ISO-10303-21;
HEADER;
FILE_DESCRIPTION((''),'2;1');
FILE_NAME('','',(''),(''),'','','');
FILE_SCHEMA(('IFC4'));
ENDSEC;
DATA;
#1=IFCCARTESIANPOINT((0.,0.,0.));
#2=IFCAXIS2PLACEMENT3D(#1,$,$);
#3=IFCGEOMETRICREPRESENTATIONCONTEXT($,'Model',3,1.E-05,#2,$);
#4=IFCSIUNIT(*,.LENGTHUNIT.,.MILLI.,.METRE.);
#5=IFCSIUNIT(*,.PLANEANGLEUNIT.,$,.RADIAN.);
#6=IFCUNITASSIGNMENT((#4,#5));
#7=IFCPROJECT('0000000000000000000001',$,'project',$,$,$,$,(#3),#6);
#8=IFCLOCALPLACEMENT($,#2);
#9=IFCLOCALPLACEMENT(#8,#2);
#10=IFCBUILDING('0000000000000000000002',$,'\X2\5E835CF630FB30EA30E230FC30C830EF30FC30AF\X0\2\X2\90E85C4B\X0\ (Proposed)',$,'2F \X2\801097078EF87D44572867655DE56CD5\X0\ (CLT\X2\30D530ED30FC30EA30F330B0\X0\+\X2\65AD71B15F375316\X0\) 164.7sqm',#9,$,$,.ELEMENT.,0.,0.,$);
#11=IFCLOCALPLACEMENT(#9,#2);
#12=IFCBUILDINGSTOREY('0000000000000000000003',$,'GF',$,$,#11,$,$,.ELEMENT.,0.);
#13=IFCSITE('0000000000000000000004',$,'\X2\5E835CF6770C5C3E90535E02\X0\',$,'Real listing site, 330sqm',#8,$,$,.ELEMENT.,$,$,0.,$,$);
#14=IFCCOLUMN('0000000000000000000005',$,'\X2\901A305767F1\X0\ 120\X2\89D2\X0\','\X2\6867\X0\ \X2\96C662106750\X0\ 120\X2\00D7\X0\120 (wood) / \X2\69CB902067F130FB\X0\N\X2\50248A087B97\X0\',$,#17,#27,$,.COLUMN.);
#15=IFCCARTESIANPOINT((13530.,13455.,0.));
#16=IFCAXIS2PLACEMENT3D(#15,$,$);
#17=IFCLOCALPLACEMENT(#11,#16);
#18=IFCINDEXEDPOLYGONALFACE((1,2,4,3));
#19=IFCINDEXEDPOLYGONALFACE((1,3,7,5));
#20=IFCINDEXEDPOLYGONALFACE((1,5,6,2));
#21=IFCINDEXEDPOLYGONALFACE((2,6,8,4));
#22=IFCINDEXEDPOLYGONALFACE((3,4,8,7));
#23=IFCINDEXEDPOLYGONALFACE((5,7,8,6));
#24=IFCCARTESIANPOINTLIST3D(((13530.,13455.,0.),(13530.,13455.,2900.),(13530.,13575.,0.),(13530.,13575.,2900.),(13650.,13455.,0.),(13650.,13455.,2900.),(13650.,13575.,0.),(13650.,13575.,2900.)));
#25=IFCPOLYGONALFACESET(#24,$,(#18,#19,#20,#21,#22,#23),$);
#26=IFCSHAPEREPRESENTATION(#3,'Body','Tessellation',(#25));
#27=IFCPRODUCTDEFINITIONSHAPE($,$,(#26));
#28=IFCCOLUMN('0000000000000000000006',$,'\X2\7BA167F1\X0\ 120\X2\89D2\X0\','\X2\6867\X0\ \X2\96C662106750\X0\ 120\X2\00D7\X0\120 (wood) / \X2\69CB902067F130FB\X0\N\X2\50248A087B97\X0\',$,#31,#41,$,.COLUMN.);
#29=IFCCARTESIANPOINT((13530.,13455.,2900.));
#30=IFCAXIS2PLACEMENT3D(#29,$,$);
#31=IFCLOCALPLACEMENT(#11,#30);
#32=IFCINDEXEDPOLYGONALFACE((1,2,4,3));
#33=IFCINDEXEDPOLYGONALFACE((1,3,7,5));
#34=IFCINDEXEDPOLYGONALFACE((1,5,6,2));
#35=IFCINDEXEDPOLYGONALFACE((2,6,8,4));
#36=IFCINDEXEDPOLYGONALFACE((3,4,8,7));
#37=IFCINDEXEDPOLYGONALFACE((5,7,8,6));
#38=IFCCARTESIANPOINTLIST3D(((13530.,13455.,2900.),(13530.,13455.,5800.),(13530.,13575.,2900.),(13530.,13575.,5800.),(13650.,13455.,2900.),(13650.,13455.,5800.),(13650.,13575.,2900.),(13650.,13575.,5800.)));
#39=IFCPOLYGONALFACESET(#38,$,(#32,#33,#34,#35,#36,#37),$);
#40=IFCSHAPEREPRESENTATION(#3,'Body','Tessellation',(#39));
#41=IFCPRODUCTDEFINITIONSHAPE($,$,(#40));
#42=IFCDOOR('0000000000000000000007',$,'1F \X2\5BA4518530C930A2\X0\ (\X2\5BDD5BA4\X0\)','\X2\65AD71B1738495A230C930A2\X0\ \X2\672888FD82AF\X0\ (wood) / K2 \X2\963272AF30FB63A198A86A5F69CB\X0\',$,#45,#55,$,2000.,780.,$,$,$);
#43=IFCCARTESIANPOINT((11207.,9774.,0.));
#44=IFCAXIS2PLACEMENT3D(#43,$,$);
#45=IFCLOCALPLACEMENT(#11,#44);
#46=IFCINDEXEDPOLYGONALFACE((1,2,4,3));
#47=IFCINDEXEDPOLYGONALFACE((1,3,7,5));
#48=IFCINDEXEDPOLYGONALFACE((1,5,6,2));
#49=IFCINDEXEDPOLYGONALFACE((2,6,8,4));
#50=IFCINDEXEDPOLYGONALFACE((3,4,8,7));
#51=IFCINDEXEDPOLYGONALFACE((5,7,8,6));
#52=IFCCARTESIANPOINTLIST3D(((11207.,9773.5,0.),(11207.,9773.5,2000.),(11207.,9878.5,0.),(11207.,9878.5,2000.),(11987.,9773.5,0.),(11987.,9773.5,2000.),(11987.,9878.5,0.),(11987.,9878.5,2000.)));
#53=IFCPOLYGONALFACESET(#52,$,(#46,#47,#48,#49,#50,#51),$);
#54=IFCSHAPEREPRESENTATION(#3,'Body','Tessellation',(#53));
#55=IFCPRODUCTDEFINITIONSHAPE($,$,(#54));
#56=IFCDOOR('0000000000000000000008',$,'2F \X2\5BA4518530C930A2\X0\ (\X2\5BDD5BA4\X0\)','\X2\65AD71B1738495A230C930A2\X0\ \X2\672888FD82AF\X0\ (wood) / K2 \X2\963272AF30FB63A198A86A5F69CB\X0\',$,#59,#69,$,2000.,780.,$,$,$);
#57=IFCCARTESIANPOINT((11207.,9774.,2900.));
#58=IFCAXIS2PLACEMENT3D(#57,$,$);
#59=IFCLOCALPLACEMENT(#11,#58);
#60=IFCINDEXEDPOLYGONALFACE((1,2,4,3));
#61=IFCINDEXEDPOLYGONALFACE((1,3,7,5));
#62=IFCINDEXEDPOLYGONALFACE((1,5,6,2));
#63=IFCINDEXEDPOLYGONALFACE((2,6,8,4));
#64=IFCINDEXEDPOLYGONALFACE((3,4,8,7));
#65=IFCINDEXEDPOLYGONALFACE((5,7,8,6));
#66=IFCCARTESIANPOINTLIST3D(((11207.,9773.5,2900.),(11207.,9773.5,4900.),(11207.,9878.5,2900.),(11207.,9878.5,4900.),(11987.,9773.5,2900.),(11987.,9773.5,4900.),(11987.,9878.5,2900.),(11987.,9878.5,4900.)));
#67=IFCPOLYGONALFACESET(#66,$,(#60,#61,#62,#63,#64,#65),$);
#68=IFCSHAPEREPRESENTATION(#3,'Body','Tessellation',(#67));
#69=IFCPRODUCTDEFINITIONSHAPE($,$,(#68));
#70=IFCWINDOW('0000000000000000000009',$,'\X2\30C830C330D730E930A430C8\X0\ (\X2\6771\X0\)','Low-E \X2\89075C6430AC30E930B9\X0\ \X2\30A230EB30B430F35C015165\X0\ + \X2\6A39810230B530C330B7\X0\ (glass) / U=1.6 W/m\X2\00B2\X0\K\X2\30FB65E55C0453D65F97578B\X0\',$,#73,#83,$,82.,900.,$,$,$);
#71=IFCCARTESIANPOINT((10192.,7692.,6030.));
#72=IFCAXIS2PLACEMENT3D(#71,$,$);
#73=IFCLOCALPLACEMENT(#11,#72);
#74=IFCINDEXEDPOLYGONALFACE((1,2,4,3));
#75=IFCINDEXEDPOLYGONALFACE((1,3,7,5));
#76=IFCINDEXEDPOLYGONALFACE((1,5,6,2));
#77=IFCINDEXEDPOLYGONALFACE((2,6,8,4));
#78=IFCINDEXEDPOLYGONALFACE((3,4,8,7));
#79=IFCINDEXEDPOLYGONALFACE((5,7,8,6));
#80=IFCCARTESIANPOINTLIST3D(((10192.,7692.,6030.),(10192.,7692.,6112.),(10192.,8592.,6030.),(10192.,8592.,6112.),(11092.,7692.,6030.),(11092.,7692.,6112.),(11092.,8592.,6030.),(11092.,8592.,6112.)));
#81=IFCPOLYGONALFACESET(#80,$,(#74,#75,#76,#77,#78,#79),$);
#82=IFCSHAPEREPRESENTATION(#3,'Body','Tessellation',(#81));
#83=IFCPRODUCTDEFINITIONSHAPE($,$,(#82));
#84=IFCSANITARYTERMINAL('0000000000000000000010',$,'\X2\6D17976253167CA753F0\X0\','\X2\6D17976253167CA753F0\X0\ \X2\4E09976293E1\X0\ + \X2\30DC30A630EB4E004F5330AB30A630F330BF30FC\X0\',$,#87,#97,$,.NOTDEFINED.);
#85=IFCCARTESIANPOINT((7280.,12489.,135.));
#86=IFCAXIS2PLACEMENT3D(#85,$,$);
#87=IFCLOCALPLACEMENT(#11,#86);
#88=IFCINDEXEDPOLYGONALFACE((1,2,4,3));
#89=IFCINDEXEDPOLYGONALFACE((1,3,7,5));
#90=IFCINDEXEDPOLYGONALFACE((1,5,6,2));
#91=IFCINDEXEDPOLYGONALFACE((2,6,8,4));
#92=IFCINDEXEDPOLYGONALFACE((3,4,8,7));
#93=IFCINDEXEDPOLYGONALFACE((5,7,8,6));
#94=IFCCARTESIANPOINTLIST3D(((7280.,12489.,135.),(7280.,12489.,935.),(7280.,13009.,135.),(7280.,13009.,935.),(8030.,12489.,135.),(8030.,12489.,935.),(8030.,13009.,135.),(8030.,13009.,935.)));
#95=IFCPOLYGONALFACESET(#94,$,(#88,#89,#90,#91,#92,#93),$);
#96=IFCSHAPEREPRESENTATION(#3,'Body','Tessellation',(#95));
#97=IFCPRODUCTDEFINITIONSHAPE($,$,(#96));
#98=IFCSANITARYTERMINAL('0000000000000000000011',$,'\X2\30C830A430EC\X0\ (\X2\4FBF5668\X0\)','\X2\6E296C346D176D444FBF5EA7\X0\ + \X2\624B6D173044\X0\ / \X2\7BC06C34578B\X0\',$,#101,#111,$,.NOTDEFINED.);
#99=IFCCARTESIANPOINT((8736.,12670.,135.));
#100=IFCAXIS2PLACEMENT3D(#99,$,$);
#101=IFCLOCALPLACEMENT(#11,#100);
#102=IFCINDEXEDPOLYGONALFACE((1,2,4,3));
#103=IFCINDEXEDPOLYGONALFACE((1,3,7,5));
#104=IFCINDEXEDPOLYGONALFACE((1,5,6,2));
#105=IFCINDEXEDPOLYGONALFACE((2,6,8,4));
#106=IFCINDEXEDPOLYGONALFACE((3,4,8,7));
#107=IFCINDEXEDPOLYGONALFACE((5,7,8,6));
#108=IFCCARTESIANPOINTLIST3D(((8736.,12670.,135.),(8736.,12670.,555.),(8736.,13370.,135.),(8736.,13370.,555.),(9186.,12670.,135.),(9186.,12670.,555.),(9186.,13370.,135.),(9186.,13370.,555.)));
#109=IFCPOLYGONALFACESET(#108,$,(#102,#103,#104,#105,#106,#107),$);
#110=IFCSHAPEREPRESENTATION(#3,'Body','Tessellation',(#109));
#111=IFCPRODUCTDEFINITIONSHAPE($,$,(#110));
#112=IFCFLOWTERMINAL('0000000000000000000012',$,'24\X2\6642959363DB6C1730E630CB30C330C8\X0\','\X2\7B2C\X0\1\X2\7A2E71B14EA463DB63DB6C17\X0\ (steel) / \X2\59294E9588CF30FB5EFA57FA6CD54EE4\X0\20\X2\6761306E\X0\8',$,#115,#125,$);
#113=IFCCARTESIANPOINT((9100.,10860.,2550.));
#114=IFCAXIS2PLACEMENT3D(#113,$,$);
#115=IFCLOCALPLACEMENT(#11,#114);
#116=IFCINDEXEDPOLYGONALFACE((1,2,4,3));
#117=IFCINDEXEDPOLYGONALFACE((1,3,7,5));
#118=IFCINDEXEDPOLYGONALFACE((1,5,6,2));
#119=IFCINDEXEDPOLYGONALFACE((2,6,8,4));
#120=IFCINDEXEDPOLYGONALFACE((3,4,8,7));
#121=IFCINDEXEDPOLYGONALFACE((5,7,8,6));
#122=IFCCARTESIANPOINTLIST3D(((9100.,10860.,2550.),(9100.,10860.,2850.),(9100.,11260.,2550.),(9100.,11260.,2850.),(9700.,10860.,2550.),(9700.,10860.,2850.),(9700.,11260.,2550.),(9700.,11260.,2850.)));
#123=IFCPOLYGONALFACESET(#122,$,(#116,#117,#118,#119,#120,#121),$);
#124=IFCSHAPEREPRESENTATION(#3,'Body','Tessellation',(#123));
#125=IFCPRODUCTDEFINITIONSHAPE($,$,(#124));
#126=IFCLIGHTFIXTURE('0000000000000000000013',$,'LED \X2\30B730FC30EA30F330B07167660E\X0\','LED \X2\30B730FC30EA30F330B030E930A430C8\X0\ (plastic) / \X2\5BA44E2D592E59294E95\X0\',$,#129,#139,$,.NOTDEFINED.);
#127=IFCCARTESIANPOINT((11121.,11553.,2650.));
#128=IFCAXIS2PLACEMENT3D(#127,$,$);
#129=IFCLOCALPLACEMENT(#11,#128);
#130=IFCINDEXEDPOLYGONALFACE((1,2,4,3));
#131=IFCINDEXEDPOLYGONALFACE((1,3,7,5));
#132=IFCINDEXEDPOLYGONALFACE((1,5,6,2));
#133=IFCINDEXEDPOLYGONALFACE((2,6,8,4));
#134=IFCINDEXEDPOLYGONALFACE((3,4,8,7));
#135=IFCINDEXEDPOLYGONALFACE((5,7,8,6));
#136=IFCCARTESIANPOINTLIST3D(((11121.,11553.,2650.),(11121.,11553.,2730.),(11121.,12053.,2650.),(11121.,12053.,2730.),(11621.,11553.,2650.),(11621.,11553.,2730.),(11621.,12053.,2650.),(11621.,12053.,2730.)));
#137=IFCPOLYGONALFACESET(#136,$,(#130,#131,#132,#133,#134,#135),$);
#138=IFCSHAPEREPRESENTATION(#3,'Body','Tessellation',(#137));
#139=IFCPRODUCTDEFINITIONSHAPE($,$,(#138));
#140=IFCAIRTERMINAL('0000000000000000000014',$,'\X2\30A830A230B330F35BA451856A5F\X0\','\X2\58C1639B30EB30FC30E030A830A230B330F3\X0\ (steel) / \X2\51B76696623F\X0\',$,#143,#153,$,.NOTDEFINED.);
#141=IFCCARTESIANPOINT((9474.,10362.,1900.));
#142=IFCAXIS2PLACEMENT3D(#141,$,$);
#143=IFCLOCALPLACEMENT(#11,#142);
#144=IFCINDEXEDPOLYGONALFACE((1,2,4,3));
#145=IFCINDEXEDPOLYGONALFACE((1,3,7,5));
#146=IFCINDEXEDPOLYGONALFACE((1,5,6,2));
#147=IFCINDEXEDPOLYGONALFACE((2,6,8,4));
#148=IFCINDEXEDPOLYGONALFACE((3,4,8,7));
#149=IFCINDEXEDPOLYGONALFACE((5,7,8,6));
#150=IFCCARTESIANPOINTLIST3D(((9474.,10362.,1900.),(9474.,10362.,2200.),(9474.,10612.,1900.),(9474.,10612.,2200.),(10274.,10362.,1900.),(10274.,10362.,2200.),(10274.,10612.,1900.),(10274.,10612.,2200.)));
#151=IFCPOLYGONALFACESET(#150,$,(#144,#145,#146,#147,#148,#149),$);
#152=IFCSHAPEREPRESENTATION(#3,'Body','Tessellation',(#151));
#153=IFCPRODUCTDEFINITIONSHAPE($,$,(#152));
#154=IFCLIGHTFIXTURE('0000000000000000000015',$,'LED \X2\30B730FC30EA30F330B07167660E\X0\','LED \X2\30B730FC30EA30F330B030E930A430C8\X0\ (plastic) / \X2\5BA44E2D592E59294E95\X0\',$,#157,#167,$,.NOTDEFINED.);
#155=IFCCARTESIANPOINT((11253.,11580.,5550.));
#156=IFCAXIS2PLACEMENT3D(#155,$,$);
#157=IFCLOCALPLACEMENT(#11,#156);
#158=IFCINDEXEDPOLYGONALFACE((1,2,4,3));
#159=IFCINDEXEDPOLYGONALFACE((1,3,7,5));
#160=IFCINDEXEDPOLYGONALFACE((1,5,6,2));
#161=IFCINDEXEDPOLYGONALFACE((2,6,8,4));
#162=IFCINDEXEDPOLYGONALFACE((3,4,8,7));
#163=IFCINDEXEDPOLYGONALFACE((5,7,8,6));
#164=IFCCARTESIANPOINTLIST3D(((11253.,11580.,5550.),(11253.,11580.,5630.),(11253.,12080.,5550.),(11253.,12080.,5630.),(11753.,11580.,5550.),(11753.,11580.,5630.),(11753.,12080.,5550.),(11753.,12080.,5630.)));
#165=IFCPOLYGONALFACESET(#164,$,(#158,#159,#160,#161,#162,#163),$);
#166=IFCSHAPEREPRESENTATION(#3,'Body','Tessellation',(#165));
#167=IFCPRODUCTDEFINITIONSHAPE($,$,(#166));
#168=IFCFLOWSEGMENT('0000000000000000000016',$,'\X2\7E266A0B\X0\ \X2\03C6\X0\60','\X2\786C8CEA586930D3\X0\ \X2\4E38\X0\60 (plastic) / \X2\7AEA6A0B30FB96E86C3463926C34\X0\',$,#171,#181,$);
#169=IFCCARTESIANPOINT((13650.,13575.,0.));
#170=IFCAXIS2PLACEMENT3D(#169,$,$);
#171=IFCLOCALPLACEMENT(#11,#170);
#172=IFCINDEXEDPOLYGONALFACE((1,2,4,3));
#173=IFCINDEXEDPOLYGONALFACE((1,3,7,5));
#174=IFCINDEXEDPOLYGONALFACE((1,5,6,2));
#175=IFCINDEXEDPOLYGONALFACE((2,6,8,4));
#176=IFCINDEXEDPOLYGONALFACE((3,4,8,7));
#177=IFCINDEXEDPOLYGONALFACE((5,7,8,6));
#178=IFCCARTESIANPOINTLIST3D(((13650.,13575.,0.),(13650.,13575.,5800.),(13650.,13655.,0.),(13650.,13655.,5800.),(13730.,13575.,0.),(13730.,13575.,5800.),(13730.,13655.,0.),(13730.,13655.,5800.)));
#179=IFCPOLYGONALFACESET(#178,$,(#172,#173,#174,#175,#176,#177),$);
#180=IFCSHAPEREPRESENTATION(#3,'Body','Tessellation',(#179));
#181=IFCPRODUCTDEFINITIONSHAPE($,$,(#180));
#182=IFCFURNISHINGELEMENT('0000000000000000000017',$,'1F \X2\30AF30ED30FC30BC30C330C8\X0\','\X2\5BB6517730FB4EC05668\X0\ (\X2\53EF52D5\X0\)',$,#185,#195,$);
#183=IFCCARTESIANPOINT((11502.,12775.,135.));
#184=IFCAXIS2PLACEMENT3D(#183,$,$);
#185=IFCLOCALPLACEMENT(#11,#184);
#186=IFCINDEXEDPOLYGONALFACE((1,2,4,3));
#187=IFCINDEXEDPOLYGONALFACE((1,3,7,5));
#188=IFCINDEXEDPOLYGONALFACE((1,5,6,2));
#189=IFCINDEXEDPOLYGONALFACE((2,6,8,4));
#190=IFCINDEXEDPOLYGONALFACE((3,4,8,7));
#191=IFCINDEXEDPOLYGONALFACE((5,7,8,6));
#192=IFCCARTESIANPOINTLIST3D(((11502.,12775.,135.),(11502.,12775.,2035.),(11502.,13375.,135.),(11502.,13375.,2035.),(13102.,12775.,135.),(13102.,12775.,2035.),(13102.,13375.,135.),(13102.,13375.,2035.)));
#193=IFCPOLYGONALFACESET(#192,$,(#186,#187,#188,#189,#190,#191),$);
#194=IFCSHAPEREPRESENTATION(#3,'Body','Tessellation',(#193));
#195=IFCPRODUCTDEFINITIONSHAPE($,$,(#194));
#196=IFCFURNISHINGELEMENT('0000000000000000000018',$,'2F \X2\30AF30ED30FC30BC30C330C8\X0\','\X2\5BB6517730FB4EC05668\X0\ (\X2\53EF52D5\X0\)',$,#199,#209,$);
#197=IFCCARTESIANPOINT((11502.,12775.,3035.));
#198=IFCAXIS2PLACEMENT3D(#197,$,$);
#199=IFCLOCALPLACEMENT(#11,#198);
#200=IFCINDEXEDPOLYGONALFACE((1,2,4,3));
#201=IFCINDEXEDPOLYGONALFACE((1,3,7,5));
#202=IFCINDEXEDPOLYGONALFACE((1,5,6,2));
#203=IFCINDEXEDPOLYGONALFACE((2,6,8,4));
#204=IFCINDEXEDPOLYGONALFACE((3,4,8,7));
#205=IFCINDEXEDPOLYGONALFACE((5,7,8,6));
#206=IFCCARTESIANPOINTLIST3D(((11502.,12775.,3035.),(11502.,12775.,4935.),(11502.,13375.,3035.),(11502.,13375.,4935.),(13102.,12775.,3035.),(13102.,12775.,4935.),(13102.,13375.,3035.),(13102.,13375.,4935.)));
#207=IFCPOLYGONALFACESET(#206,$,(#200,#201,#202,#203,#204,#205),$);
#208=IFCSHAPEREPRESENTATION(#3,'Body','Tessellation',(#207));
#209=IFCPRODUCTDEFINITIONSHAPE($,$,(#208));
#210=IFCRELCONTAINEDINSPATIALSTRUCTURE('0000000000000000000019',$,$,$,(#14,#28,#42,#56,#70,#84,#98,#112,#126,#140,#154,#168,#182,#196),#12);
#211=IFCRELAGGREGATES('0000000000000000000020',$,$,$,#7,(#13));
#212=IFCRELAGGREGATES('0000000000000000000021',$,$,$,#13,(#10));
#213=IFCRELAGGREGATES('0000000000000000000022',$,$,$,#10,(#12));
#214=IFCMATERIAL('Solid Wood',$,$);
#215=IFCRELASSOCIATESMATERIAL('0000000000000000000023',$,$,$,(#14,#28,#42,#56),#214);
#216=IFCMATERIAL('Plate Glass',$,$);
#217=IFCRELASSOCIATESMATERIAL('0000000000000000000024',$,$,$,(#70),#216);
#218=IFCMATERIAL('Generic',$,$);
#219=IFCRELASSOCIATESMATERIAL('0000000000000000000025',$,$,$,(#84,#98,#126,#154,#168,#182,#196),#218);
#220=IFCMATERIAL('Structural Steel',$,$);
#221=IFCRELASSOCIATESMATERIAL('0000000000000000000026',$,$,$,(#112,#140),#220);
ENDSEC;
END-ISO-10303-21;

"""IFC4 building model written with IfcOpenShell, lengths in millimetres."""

from ifc_helpers import new_model, si_unit, frame, frame_2d, origin, place, context, project, spatial, rectangle, extrude, material, element, save


model = new_model("IFC4")

# Units and contexts
model_context = context("Model", 3, precision=1e-05, world=origin())
ifc_project = project(units=[si_unit("LENGTHUNIT", "METRE", prefix="MILLI"), si_unit("PLANEANGLEUNIT", "RADIAN")], contexts=[model_context])

# Site, building, storey
site_placement = place(None, origin())
site = spatial("IfcSite", under=ifc_project, at=site_placement, Name="広島県尾道市", ObjectType="Real listing site, 330sqm", CompositionType="ELEMENT", RefElevation=0.0)
building_placement = place(site_placement, origin())
building = spatial("IfcBuilding", under=site, at=building_placement, Name="広島・リモートワーク2部屋 (Proposed)", ObjectType="2F 耐震軸組在来工法 (CLTフローリング+断熱強化) 164.7sqm", CompositionType="ELEMENT", ElevationOfRefHeight=0.0, ElevationOfTerrain=0.0)
storey_placement = place(building_placement, origin())
storey = spatial("IfcBuildingStorey", under=building, at=storey_placement, Name="GF", CompositionType="ELEMENT", Elevation=0.0)

# Columns
ifc_material_1 = material(Name="Solid Wood")
column_1_placement = place(storey_placement, frame((13530.0, 13455.0, 0.0)))
element("IfcColumn", 1, at=column_1_placement, inside=storey, material=ifc_material_1, Name="通し柱 120角", Description="桧 集成材 120×120 (wood) / 構造柱・N値計算", PredefinedType="COLUMN", context=model_context, shape_type="SweptSolid", body=[
    extrude(rectangle(XDim=120.0, YDim=120.0, at=frame_2d((60.0, 60.0))), frame((13530.0, 13455.0, 0.0)), (0.0, 0.0, 1.0), 2900.0),
])
column_2_placement = place(storey_placement, frame((13530.0, 13455.0, 2900.0)))
element("IfcColumn", 2, at=column_2_placement, inside=storey, material=ifc_material_1, Name="管柱 120角", Description="桧 集成材 120×120 (wood) / 構造柱・N値計算", PredefinedType="COLUMN", context=model_context, shape_type="SweptSolid", body=[
    extrude(rectangle(XDim=120.0, YDim=120.0, at=frame_2d((60.0, 60.0))), frame((13530.0, 13455.0, 2900.0)), (0.0, 0.0, 1.0), 2900.0),
])

# Door
door_1_placement = place(storey_placement, frame((11207.0, 9774.0, 0.0)))
element("IfcDoor", 3, at=door_1_placement, inside=storey, material=ifc_material_1, Name="1F 室内ドア (寝室)", Description="断熱玄関ドア 木製芯 (wood) / K2 防犯・採風機構", OverallHeight=2000.0, OverallWidth=780.0, context=model_context, shape_type="SweptSolid", body=[
    extrude(rectangle(XDim=780.0, YDim=105.0, at=frame_2d((390.0, 52.0))), frame((11207.0, 9774.0, 0.0)), (0.0, 0.0, 1.0), 2000.0),
])

# Door
door_2_placement = place(storey_placement, frame((11207.0, 9774.0, 2900.0)))
element("IfcDoor", 4, at=door_2_placement, inside=storey, material=ifc_material_1, Name="2F 室内ドア (寝室)", Description="断熱玄関ドア 木製芯 (wood) / K2 防犯・採風機構", OverallHeight=2000.0, OverallWidth=780.0, context=model_context, shape_type="SweptSolid", body=[
    extrude(rectangle(XDim=780.0, YDim=105.0, at=frame_2d((390.0, 52.0))), frame((11207.0, 9774.0, 2900.0)), (0.0, 0.0, 1.0), 2000.0),
])

# Window
ifc_material_2 = material(Name="Plate Glass")
window_placement = place(storey_placement, frame((10192.0, 7692.0, 6030.0)))
element("IfcWindow", 5, at=window_placement, inside=storey, material=ifc_material_2, Name="トップライト (東)", Description="Low-E 複層ガラス アルゴン封入 + 樹脂サッシ (glass) / U=1.6 W/m²K・日射取得型", OverallHeight=82.0, OverallWidth=900.0, context=model_context, shape_type="SweptSolid", body=[
    extrude(rectangle(XDim=900.0, YDim=900.0, at=frame_2d((450.0, 450.0))), frame((10192.0, 7692.0, 6030.0)), (0.0, 0.0, 1.0), 82.0),
])

# Sanitary terminals
ifc_material_3 = material(Name="Generic")
sanitary_terminal_1_placement = place(storey_placement, frame((7280.0, 12489.0, 135.0)))
element("IfcSanitaryTerminal", 6, at=sanitary_terminal_1_placement, inside=storey, material=ifc_material_3, Name="洗面化粧台", Description="洗面化粧台 三面鏡 + ボウル一体カウンター", PredefinedType="NOTDEFINED", context=model_context, shape_type="SweptSolid", body=[
    extrude(rectangle(XDim=750.0, YDim=520.0, at=frame_2d((375.0, 260.0))), frame((7280.0, 12489.0, 135.0)), (0.0, 0.0, 1.0), 800.0),
])
sanitary_terminal_2_placement = place(storey_placement, frame((8736.0, 12670.0, 135.0)))
element("IfcSanitaryTerminal", 7, at=sanitary_terminal_2_placement, inside=storey, material=ifc_material_3, Name="トイレ (便器)", Description="温水洗浄便座 + 手洗い / 節水型", PredefinedType="NOTDEFINED", context=model_context, shape_type="SweptSolid", body=[
    extrude(rectangle(XDim=450.0, YDim=700.0, at=frame_2d((225.0, 350.0))), frame((8736.0, 12670.0, 135.0)), (0.0, 0.0, 1.0), 420.0),
])

# Flow terminal
ifc_material_4 = material(Name="Structural Steel")
flow_terminal_placement = place(storey_placement, frame((9100.0, 10860.0, 2550.0)))
element("IfcFlowTerminal", 8, at=flow_terminal_placement, inside=storey, material=ifc_material_4, Name="24時間換気ユニット", Description="第1種熱交換換気 (steel) / 天井裏・建基法令20条の8", context=model_context, shape_type="SweptSolid", body=[
    extrude(rectangle(XDim=600.0, YDim=400.0, at=frame_2d((300.0, 200.0))), frame((9100.0, 10860.0, 2550.0)), (0.0, 0.0, 1.0), 300.0),
])

# Light fixture
light_fixture_1_placement = place(storey_placement, frame((11121.0, 11553.0, 2650.0)))
element("IfcLightFixture", 9, at=light_fixture_1_placement, inside=storey, material=ifc_material_3, Name="LED シーリング照明", Description="LED シーリングライト (plastic) / 室中央天井", PredefinedType="NOTDEFINED", context=model_context, shape_type="SweptSolid", body=[
    extrude(rectangle(XDim=500.0, YDim=500.0, at=frame_2d((250.0, 250.0))), frame((11121.0, 11553.0, 2650.0)), (0.0, 0.0, 1.0), 80.0),
])

# Air terminal
air_terminal_placement = place(storey_placement, frame((9474.0, 10362.0, 1900.0)))
element("IfcAirTerminal", 10, at=air_terminal_placement, inside=storey, material=ifc_material_4, Name="エアコン室内機", Description="壁掛ルームエアコン (steel) / 冷暖房", PredefinedType="NOTDEFINED", context=model_context, shape_type="SweptSolid", body=[
    extrude(rectangle(XDim=800.0, YDim=250.0, at=frame_2d((400.0, 125.0))), frame((9474.0, 10362.0, 1900.0)), (0.0, 0.0, 1.0), 300.0),
])

# Light fixture
light_fixture_2_placement = place(storey_placement, frame((11253.0, 11580.0, 5550.0)))
element("IfcLightFixture", 11, at=light_fixture_2_placement, inside=storey, material=ifc_material_3, Name="LED シーリング照明", Description="LED シーリングライト (plastic) / 室中央天井", PredefinedType="NOTDEFINED", context=model_context, shape_type="SweptSolid", body=[
    extrude(rectangle(XDim=500.0, YDim=500.0, at=frame_2d((250.0, 250.0))), frame((11253.0, 11580.0, 5550.0)), (0.0, 0.0, 1.0), 80.0),
])

# Flow segment
flow_segment_placement = place(storey_placement, frame((13650.0, 13575.0, 0.0)))
element("IfcFlowSegment", 12, at=flow_segment_placement, inside=storey, material=ifc_material_3, Name="縦樋 φ60", Description="硬質塩ビ 丸60 (plastic) / 竪樋・雨水排水", context=model_context, shape_type="SweptSolid", body=[
    extrude(rectangle(XDim=80.0, YDim=80.0, at=frame_2d((40.0, 40.0))), frame((13650.0, 13575.0, 0.0)), (0.0, 0.0, 1.0), 5800.0),
])

# Furnishing elements
furnishing_1_placement = place(storey_placement, frame((11502.0, 12775.0, 135.0)))
element("IfcFurnishingElement", 13, at=furnishing_1_placement, inside=storey, material=ifc_material_3, Name="1F クローゼット", Description="家具・什器 (可動)", context=model_context, shape_type="SweptSolid", body=[
    extrude(rectangle(XDim=1600.0, YDim=600.0, at=frame_2d((800.0, 300.0))), frame((11502.0, 12775.0, 135.0)), (0.0, 0.0, 1.0), 1900.0),
])
furnishing_2_placement = place(storey_placement, frame((11502.0, 12775.0, 3035.0)))
element("IfcFurnishingElement", 14, at=furnishing_2_placement, inside=storey, material=ifc_material_3, Name="2F クローゼット", Description="家具・什器 (可動)", context=model_context, shape_type="SweptSolid", body=[
    extrude(rectangle(XDim=1600.0, YDim=600.0, at=frame_2d((800.0, 300.0))), frame((11502.0, 12775.0, 3035.0)), (0.0, 0.0, 1.0), 1900.0),
])

save(model, "model.ifc")
